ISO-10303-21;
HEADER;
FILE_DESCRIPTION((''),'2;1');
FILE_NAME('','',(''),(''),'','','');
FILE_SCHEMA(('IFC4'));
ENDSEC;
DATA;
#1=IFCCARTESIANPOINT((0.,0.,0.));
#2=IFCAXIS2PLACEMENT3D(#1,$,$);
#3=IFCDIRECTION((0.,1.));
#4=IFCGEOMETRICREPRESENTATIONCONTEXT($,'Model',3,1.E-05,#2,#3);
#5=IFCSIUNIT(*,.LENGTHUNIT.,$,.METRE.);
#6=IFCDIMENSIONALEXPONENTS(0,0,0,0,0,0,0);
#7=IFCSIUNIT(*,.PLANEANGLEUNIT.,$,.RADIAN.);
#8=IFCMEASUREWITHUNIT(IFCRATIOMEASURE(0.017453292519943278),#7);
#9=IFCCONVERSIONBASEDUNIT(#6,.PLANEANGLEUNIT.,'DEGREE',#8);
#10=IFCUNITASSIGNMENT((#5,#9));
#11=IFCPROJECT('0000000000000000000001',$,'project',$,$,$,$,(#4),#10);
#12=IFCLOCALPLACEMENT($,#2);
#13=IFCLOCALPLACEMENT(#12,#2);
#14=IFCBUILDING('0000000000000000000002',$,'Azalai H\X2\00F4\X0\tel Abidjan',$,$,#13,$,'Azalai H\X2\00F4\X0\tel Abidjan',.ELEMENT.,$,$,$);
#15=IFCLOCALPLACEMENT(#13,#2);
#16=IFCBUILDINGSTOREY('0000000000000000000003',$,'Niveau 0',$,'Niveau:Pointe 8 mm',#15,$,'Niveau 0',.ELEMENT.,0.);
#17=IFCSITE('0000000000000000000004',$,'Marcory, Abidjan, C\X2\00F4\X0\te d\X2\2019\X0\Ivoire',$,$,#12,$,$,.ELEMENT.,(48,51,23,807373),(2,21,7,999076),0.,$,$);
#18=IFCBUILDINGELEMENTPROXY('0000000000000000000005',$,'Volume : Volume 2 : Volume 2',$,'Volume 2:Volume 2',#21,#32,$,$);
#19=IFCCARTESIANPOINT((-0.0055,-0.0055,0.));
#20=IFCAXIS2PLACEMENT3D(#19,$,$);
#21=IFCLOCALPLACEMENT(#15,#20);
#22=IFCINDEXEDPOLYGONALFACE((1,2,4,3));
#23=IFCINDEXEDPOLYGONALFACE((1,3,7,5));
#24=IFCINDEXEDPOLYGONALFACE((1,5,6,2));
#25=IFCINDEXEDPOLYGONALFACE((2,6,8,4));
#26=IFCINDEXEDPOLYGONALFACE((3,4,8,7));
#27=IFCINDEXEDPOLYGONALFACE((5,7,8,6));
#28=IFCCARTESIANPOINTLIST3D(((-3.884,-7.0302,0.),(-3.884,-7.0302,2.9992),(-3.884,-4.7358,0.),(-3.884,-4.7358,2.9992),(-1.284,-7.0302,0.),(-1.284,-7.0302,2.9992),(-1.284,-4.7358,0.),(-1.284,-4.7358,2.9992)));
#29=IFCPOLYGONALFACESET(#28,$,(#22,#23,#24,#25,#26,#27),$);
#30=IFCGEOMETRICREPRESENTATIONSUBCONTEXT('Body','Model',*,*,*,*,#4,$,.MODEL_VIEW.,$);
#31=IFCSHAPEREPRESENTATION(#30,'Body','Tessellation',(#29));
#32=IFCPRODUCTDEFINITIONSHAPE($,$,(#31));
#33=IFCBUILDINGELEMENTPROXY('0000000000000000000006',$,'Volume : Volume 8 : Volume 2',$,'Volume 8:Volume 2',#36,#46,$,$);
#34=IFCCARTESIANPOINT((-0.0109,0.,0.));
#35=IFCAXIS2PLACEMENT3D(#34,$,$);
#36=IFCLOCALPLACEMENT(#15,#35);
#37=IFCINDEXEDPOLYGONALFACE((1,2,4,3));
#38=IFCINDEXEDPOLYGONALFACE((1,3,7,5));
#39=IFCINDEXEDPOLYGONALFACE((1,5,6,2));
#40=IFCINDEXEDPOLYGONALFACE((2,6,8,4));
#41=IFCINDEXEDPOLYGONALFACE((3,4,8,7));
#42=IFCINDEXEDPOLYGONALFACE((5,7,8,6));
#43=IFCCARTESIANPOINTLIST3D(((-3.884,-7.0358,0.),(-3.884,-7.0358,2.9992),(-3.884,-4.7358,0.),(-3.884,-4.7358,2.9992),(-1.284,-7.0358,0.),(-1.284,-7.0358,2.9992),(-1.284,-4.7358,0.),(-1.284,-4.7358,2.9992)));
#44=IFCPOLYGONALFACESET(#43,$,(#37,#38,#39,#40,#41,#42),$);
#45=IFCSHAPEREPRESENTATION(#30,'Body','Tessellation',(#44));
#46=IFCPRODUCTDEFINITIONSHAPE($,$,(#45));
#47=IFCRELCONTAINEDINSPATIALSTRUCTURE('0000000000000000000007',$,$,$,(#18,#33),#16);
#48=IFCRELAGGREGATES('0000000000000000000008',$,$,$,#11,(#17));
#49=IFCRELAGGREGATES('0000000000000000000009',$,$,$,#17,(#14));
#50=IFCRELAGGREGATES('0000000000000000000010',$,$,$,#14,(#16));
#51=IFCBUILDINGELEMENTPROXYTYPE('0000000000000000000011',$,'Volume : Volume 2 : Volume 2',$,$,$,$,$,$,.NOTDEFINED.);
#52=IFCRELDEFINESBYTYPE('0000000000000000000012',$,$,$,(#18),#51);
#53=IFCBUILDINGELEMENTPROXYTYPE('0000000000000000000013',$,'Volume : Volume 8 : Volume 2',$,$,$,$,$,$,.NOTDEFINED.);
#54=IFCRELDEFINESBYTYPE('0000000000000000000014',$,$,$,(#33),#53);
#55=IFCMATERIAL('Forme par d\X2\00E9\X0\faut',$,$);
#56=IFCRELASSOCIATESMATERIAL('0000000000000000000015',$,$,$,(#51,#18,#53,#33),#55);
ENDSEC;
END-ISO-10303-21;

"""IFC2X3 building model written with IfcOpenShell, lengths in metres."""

from ifc_helpers import new_model, entity, si_unit, converted_unit, direction, frame, frame_2d, origin, place, context, subcontext, project, spatial, rectangle, extrude, source, transform, mapped, material, type_object, type_shapes, element, save


model = new_model("IFC2X3")

# Units and contexts
model_context = context("Model", 3, precision=1e-05, world=origin(), true_north=direction((0.0, 1.0)))
body_context = subcontext(model_context, "Body", "Model", "MODEL_VIEW")
ifc_project = project(units=[si_unit("LENGTHUNIT", "METRE"), converted_unit("PLANEANGLEUNIT", "DEGREE", entity("IfcRatioMeasure", 0.017453292519943278), si_unit("PLANEANGLEUNIT", "RADIAN"), dimensions=[0, 0, 0, 0, 0, 0, 0])], contexts=[model_context])

# Site, building, storey
site_placement = place(None, origin())
site = spatial("IfcSite", under=ifc_project, at=site_placement, Name="Marcory, Abidjan, Côte d’Ivoire", CompositionType="ELEMENT", RefLatitude=(48, 51, 23, 807373), RefLongitude=(2, 21, 7, 999076), RefElevation=0.0)
building_placement = place(site_placement, origin())
building = spatial("IfcBuilding", under=site, at=building_placement, Name="Azalai Hôtel Abidjan", LongName="Azalai Hôtel Abidjan", CompositionType="ELEMENT")
storey_placement = place(building_placement, origin())
storey = spatial("IfcBuildingStorey", under=building, at=storey_placement, Name="Niveau 0", ObjectType="Niveau:Pointe 8 mm", LongName="Niveau 0", CompositionType="ELEMENT", Elevation=0.0)

# Building element proxies
ifc_material_1 = material(Name="Forme par défaut")
building_element_proxy_type_1 = type_object("IfcBuildingElementProxyType", Name="Volume : Volume 2 : Volume 2", PredefinedType="NOTDEFINED", material=ifc_material_1)
shared_shape_1 = source(origin(), body_context, "Body", "SweptSolid", [
    extrude(rectangle(XDim=2.9992, YDim=2.2945, at=frame_2d((0.0, 0.0), x_axis=(1.0, 0.0))), frame((-3.884, -5.883, 1.4996), z_axis=(1.0, 0.0, 0.0), x_axis=(0.0, 0.0, 1.0)), (0.0, 0.0, 1.0), 2.6),
])
type_shapes(building_element_proxy_type_1, [shared_shape_1])
proxy_1_placement = place(storey_placement, frame((-0.0055, -0.0055, 0.0)))
element("IfcBuildingElementProxy", 1, at=proxy_1_placement, inside=storey, type_object=building_element_proxy_type_1, material=ifc_material_1, Name="Volume : Volume 2 : Volume 2", ObjectType="Volume 2:Volume 2", context=body_context, shape_type="MappedRepresentation", body=[
    mapped(shared_shape_1, transform((0.0, 0.0, 0.0), scale=1.0)),
])
building_element_proxy_type_2 = type_object("IfcBuildingElementProxyType", Name="Volume : Volume 8 : Volume 2", PredefinedType="NOTDEFINED", material=ifc_material_1)
shared_shape_2 = source(origin(), body_context, "Body", "SweptSolid", [
    extrude(rectangle(XDim=2.9992, YDim=2.3, at=frame_2d((0.0, 0.0), x_axis=(1.0, 0.0))), frame((-3.884, -5.8858, 1.4996), z_axis=(1.0, 0.0, 0.0), x_axis=(0.0, 0.0, 1.0)), (0.0, 0.0, 1.0), 2.6),
])
type_shapes(building_element_proxy_type_2, [shared_shape_2])
proxy_2_placement = place(storey_placement, frame((-0.0109, 0.0, 0.0)))
element("IfcBuildingElementProxy", 2, at=proxy_2_placement, inside=storey, type_object=building_element_proxy_type_2, material=ifc_material_1, Name="Volume : Volume 8 : Volume 2", ObjectType="Volume 8:Volume 2", context=body_context, shape_type="MappedRepresentation", body=[
    mapped(shared_shape_2, transform((0.0, 0.0, 0.0), scale=1.0)),
])

save(model, "model.ifc")
